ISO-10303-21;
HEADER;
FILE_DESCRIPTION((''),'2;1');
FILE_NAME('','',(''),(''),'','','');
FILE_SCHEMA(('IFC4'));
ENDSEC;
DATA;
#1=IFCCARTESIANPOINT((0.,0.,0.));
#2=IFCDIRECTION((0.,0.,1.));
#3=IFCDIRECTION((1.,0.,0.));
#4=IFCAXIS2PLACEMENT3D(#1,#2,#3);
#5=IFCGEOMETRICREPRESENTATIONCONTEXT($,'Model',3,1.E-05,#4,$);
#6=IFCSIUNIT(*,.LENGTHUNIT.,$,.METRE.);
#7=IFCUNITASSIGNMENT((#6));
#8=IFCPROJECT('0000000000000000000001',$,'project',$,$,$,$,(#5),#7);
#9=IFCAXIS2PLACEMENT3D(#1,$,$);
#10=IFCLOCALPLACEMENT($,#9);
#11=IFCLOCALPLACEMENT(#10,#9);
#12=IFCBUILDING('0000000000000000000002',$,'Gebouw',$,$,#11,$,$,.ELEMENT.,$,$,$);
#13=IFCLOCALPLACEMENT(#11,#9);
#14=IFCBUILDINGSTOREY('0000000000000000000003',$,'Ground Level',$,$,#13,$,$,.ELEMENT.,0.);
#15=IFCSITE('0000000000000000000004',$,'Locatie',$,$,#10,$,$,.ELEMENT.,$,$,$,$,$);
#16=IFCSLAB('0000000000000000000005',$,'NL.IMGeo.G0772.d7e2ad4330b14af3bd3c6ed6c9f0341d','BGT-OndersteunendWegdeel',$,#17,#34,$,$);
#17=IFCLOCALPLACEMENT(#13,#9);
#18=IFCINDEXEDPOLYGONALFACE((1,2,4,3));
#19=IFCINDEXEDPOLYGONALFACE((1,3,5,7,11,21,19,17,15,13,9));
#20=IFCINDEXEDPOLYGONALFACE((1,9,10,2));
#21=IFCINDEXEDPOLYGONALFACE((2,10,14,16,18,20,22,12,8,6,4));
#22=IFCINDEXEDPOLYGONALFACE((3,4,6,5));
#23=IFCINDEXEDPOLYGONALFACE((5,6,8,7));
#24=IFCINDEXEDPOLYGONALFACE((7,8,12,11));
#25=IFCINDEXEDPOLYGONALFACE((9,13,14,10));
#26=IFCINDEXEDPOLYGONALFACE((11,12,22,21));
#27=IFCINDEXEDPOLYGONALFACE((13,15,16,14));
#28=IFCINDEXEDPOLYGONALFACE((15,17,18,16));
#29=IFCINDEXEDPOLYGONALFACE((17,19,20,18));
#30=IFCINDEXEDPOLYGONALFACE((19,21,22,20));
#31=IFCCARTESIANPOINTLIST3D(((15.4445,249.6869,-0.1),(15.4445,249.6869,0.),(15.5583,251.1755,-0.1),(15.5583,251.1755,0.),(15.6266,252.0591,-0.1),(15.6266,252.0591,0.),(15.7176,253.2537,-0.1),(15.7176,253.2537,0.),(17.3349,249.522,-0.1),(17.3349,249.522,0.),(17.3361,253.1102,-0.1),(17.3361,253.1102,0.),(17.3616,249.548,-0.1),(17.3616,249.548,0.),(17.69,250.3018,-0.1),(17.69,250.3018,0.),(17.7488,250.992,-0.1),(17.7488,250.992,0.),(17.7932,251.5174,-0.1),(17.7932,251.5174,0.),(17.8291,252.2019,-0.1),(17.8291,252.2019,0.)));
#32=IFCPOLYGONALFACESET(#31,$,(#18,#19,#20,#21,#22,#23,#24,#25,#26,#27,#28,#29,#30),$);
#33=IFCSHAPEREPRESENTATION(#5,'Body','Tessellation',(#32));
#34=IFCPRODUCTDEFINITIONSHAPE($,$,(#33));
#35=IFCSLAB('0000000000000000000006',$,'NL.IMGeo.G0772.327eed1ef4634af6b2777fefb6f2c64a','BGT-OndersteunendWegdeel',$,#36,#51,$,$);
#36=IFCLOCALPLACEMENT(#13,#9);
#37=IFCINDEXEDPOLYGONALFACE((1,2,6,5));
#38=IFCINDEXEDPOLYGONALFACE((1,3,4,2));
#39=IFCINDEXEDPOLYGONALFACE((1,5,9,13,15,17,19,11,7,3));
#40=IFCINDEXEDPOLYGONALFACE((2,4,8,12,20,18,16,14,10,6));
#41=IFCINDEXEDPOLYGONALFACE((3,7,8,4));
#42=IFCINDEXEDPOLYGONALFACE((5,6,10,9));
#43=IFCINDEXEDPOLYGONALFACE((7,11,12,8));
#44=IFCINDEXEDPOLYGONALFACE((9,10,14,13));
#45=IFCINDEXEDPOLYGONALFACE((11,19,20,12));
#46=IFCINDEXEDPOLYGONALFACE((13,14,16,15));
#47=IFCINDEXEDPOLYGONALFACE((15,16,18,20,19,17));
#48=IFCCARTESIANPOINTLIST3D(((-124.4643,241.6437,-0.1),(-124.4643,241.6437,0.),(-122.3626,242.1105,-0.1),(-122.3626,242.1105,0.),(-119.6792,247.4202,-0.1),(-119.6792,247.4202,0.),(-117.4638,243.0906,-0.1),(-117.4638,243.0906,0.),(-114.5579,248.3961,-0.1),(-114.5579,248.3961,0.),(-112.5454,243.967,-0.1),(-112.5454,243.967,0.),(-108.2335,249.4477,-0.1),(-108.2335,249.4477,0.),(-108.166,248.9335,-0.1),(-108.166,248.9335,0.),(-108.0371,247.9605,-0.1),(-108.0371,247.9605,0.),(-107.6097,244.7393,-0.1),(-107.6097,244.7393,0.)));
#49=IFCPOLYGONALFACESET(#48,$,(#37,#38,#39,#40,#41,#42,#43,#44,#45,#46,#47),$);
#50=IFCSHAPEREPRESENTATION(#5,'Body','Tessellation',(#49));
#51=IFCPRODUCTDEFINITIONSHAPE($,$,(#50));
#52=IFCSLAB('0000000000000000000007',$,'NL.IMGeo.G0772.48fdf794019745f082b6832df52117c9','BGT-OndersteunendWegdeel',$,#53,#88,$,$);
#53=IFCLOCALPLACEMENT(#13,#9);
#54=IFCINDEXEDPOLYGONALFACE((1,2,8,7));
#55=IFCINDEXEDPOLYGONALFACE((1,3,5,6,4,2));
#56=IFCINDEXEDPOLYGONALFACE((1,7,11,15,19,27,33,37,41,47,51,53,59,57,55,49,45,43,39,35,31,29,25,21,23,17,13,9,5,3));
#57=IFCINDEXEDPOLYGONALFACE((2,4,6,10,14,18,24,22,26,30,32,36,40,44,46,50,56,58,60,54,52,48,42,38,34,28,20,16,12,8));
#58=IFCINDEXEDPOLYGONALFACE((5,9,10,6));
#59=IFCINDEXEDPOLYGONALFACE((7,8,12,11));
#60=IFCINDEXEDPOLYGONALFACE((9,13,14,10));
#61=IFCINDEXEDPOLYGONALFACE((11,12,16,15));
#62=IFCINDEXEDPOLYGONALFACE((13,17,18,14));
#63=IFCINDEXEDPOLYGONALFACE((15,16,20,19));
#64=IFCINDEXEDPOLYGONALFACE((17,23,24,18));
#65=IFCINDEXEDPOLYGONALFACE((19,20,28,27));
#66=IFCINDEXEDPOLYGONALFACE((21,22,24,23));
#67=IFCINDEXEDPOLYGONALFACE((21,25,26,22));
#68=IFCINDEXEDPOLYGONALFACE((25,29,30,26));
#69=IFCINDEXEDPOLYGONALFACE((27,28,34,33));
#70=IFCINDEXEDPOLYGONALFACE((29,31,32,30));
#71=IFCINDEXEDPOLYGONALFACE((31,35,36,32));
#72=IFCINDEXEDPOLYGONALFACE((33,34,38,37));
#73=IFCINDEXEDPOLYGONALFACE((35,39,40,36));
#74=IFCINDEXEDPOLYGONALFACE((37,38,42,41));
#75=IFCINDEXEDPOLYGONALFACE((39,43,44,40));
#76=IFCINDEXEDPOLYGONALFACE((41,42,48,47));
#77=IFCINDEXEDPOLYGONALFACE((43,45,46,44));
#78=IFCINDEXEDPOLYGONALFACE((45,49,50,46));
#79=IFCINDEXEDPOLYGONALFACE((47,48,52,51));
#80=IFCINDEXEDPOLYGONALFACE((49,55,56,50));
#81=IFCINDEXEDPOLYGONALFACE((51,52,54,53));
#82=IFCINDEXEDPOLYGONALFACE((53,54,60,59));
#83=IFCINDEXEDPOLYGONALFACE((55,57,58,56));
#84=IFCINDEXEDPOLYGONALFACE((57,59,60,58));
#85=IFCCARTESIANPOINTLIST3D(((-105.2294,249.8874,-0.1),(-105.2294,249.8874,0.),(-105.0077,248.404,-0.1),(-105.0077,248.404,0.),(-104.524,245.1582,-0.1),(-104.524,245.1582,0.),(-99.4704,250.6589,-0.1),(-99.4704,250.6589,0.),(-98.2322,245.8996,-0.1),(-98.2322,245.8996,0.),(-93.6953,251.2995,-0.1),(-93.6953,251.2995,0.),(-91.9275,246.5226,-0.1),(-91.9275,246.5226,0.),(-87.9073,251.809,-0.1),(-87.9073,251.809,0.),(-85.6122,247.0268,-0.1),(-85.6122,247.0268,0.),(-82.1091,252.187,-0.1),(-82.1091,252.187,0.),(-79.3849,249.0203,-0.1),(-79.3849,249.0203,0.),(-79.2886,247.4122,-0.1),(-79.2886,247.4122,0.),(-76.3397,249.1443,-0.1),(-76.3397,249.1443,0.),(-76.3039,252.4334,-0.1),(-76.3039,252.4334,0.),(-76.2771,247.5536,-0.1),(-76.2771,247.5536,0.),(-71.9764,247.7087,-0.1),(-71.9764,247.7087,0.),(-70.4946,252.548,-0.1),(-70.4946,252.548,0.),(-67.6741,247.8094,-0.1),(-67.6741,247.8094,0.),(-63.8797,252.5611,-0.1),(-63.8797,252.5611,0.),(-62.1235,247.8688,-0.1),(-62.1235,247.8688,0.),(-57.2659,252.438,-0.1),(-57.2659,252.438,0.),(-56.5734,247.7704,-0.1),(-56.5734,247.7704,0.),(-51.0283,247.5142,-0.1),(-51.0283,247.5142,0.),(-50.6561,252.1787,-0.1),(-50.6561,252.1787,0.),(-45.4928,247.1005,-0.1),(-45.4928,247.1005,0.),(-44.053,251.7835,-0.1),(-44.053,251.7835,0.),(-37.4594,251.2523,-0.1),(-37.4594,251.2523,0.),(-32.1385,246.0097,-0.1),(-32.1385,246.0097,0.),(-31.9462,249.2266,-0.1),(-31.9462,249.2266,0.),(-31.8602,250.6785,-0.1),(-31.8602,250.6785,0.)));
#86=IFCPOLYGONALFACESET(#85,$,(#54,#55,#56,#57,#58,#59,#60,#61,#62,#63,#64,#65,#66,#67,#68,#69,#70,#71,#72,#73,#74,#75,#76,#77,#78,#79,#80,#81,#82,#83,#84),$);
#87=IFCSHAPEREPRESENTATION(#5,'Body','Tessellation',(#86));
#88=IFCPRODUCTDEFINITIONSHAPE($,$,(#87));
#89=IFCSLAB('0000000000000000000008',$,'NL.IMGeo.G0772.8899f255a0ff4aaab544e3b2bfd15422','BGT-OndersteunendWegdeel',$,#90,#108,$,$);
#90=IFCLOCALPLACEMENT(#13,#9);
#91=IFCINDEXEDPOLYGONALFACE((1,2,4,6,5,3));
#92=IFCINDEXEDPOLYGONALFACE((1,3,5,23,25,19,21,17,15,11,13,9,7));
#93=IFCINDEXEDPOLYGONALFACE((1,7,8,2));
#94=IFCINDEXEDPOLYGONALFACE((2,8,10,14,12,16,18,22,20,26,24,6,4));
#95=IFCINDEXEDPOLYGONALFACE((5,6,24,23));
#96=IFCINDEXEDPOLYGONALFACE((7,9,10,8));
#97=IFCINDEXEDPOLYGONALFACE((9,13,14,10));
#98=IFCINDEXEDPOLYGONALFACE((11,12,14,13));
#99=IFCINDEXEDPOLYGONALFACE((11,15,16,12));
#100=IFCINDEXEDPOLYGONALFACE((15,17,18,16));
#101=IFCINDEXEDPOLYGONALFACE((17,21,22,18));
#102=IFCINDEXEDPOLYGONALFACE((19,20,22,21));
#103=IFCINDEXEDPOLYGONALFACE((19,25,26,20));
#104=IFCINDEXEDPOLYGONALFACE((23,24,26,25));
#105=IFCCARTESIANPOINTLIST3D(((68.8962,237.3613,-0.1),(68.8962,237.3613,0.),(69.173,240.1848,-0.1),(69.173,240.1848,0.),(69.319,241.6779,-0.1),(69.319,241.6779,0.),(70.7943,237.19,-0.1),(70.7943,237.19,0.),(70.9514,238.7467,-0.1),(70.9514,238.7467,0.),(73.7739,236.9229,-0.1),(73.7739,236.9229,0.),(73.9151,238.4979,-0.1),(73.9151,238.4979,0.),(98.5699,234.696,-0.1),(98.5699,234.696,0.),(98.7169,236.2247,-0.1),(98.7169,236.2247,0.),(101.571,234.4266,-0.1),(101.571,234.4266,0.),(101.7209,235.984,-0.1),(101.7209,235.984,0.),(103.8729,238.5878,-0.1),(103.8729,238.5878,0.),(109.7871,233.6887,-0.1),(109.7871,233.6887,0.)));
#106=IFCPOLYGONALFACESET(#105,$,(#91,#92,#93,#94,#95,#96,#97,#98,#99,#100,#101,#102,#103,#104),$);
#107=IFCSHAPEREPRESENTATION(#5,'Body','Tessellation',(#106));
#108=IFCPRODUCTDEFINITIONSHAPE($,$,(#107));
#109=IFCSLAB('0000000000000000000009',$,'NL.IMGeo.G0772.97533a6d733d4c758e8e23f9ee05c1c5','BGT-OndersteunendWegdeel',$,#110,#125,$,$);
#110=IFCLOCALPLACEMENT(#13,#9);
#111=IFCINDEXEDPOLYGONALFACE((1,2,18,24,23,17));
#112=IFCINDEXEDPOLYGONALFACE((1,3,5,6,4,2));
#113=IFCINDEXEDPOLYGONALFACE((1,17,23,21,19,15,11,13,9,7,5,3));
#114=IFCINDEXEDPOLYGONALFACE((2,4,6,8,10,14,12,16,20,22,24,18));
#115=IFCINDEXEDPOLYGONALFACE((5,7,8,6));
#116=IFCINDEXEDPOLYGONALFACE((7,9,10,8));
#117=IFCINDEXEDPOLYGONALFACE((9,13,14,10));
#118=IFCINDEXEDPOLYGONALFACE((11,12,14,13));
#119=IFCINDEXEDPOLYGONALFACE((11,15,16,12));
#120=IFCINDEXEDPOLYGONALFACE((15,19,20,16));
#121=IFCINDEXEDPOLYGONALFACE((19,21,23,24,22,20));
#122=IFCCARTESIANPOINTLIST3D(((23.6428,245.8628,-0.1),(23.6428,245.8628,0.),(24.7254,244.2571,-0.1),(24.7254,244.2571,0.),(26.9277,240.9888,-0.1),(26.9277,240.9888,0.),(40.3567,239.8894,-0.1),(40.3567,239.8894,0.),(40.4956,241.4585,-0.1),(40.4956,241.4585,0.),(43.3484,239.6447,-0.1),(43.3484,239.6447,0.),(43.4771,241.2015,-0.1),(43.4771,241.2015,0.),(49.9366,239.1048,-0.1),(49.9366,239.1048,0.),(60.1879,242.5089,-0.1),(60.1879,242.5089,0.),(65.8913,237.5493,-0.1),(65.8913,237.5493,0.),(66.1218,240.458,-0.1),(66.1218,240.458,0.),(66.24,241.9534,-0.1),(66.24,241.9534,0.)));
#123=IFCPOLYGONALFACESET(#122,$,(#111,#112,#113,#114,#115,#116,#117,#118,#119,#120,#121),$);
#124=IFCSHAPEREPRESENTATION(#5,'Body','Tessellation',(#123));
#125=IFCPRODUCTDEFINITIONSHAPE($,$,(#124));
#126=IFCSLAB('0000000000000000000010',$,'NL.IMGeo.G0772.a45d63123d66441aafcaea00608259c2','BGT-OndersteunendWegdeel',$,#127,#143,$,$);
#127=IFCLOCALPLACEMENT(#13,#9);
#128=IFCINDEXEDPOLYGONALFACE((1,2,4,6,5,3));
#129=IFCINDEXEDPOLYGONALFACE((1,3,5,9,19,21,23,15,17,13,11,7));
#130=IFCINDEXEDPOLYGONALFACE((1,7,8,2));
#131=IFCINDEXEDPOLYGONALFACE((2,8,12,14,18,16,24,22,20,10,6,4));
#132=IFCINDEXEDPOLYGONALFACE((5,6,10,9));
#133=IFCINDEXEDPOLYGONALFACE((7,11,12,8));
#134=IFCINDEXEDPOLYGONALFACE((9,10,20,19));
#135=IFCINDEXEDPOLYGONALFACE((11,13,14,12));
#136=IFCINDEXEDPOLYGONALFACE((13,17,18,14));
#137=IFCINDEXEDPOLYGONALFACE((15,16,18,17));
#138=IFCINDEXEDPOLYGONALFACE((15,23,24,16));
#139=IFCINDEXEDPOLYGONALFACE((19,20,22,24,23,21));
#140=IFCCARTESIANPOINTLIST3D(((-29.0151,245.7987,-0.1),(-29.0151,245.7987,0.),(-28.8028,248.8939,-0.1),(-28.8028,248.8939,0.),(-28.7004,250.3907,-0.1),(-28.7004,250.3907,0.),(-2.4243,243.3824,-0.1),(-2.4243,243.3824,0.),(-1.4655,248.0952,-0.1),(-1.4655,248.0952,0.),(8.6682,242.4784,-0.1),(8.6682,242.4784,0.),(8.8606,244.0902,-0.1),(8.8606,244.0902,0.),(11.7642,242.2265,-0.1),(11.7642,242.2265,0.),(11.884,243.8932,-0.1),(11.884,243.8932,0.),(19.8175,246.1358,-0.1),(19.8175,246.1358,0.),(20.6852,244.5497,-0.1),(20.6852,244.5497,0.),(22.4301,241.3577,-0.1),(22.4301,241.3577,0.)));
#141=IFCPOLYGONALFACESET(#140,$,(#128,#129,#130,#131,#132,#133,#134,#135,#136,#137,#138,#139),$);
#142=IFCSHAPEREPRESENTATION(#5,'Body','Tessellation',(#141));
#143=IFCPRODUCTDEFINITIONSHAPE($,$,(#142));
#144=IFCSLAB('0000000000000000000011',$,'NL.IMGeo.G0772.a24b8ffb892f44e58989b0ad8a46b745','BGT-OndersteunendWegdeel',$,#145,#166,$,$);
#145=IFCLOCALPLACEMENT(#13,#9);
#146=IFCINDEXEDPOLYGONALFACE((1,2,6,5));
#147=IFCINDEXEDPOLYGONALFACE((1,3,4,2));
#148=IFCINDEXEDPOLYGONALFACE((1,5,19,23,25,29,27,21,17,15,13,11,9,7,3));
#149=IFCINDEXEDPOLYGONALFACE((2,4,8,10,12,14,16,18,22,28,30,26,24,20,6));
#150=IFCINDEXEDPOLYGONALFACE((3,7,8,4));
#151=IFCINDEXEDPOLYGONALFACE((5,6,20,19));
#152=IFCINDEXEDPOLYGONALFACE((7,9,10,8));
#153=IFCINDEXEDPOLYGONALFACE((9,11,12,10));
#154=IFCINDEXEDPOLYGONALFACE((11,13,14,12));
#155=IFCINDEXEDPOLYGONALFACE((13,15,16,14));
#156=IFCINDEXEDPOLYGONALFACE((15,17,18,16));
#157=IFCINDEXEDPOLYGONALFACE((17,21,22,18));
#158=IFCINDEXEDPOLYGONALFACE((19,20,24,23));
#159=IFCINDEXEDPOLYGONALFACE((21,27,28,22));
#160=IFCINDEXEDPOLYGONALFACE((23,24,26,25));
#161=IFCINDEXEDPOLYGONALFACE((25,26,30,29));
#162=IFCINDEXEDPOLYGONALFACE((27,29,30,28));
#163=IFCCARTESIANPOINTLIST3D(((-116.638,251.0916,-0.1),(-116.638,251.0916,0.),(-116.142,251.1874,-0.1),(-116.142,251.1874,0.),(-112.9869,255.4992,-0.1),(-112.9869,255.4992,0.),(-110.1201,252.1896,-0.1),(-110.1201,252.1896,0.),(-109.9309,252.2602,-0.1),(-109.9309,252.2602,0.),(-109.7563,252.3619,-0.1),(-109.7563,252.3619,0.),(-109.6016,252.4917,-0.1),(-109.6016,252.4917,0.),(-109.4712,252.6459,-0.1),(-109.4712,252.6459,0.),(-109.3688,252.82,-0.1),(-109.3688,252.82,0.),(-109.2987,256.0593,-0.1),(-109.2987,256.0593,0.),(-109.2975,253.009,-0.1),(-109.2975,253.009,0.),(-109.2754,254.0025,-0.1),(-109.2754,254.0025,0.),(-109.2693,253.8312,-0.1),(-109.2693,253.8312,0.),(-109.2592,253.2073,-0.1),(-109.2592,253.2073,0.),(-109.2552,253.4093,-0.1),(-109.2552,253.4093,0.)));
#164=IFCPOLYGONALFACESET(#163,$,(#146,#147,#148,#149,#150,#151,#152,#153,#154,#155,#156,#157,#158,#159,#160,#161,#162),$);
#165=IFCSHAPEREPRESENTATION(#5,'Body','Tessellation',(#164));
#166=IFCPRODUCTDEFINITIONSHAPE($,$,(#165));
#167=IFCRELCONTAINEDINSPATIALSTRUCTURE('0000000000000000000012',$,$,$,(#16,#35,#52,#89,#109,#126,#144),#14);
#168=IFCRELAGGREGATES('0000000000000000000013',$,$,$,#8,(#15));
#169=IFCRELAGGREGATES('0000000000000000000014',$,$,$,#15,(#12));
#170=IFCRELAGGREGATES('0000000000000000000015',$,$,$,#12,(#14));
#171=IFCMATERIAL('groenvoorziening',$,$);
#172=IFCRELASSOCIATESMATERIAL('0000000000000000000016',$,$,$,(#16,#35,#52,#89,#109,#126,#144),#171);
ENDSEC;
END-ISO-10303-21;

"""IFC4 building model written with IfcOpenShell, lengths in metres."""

from ifc_helpers import new_model, si_unit, frame, origin, origin_with_axes, place, context, project, spatial, polyline, outline, extrude, material, element, save


model = new_model("IFC4")

# Units and contexts
model_context = context("Model", 3, precision=1e-05, world=origin_with_axes())
ifc_project = project(units=[si_unit("LENGTHUNIT", "METRE")], contexts=[model_context])

# Site, building, storey
site_placement = place(None, origin())
site = spatial("IfcSite", under=ifc_project, at=site_placement, Name="Locatie", CompositionType="ELEMENT")
building_placement = place(site_placement, origin())
building = spatial("IfcBuilding", under=site, at=building_placement, Name="Gebouw", CompositionType="ELEMENT")
storey_placement = place(building_placement, origin())
storey = spatial("IfcBuildingStorey", under=building, at=storey_placement, Name="Ground Level", CompositionType="ELEMENT", Elevation=0.0)

# Slabs
ifc_material_1 = material(Name="groenvoorziening")
slab_1_placement = place(storey_placement, origin())
element("IfcSlab", 1, at=slab_1_placement, inside=storey, material=ifc_material_1, Name="NL.IMGeo.G0772.d7e2ad4330b14af3bd3c6ed6c9f0341d", Description="BGT-OndersteunendWegdeel", context=model_context, shape_type="SweptSolid", body=[
    extrude(outline(polyline([(17.8291, 252.2019), (17.7932, 251.5174), (17.7488, 250.992), (17.69, 250.3018), (17.3616, 249.548), (17.3349, 249.522), (15.4445, 249.6869), (15.5583, 251.1755), (15.6266, 252.0591), (15.7176, 253.2537), (17.3361, 253.1102), (17.8291, 252.2019)])), frame((0.0, 0.0, -0.1), z_axis=(0.0, 0.0, 1.0), x_axis=(1.0, 0.0, 0.0)), (0.0, 0.0, 1.0), 0.1),
])
slab_2_placement = place(storey_placement, origin())
element("IfcSlab", 2, at=slab_2_placement, inside=storey, material=ifc_material_1, Name="NL.IMGeo.G0772.327eed1ef4634af6b2777fefb6f2c64a", Description="BGT-OndersteunendWegdeel", context=model_context, shape_type="SweptSolid", body=[
    extrude(outline(polyline([(-114.5579, 248.3961), (-108.2335, 249.4477), (-108.166, 248.9335), (-108.0371, 247.9605), (-107.6097, 244.7393), (-112.5454, 243.967), (-117.4638, 243.0906), (-122.3626, 242.1105), (-124.4643, 241.6437), (-119.6792, 247.4202), (-114.5579, 248.3961)])), frame((0.0, 0.0, -0.1), z_axis=(0.0, 0.0, 1.0), x_axis=(1.0, 0.0, 0.0)), (0.0, 0.0, 1.0), 0.1),
])
slab_3_placement = place(storey_placement, origin())
element("IfcSlab", 3, at=slab_3_placement, inside=storey, material=ifc_material_1, Name="NL.IMGeo.G0772.48fdf794019745f082b6832df52117c9", Description="BGT-OndersteunendWegdeel", context=model_context, shape_type="SweptSolid", body=[
    extrude(outline(polyline([(-99.4704, 250.6589), (-93.6953, 251.2995), (-87.9073, 251.809), (-82.1091, 252.187), (-76.3039, 252.4334), (-70.4946, 252.548), (-63.8797, 252.5611), (-57.2659, 252.438), (-50.6561, 252.1787), (-44.053, 251.7835), (-37.4594, 251.2523), (-31.8602, 250.6785), (-31.9462, 249.2266), (-32.1385, 246.0097), (-45.4928, 247.1005), (-51.0283, 247.5142), (-56.5734, 247.7704), (-62.1235, 247.8688), (-67.6741, 247.8094), (-71.9764, 247.7087), (-76.2771, 247.5536), (-76.3397, 249.1443), (-79.3849, 249.0203), (-79.2886, 247.4122), (-85.6122, 247.0268), (-91.9275, 246.5226), (-98.2322, 245.8996), (-104.524, 245.1582), (-105.0077, 248.404), (-105.2294, 249.8874), (-99.4704, 250.6589)])), frame((0.0, 0.0, -0.1), z_axis=(0.0, 0.0, 1.0), x_axis=(1.0, 0.0, 0.0)), (0.0, 0.0, 1.0), 0.1),
])
slab_4_placement = place(storey_placement, origin())
element("IfcSlab", 4, at=slab_4_placement, inside=storey, material=ifc_material_1, Name="NL.IMGeo.G0772.8899f255a0ff4aaab544e3b2bfd15422", Description="BGT-OndersteunendWegdeel", context=model_context, shape_type="SweptSolid", body=[
    extrude(outline(polyline([(101.571, 234.4266), (101.7209, 235.984), (98.7169, 236.2247), (98.5699, 234.696), (73.7739, 236.9229), (73.9151, 238.4979), (70.9514, 238.7467), (70.7943, 237.19), (68.8962, 237.3613), (69.173, 240.1848), (69.319, 241.6779), (103.8729, 238.5878), (109.7871, 233.6887), (101.571, 234.4266)])), frame((0.0, 0.0, -0.1), z_axis=(0.0, 0.0, 1.0), x_axis=(1.0, 0.0, 0.0)), (0.0, 0.0, 1.0), 0.1),
])
slab_5_placement = place(storey_placement, origin())
element("IfcSlab", 5, at=slab_5_placement, inside=storey, material=ifc_material_1, Name="NL.IMGeo.G0772.97533a6d733d4c758e8e23f9ee05c1c5", Description="BGT-OndersteunendWegdeel", context=model_context, shape_type="SweptSolid", body=[
    extrude(outline(polyline([(60.1879, 242.5089), (66.24, 241.9534), (66.1218, 240.458), (65.8913, 237.5493), (49.9366, 239.1048), (43.3484, 239.6447), (43.4771, 241.2015), (40.4956, 241.4585), (40.3567, 239.8894), (26.9277, 240.9888), (24.7254, 244.2571), (23.6428, 245.8628), (60.1879, 242.5089)])), frame((0.0, 0.0, -0.1), z_axis=(0.0, 0.0, 1.0), x_axis=(1.0, 0.0, 0.0)), (0.0, 0.0, 1.0), 0.1),
])
slab_6_placement = place(storey_placement, origin())
element("IfcSlab", 6, at=slab_6_placement, inside=storey, material=ifc_material_1, Name="NL.IMGeo.G0772.a45d63123d66441aafcaea00608259c2", Description="BGT-OndersteunendWegdeel", context=model_context, shape_type="SweptSolid", body=[
    extrude(outline(polyline([(-1.4655, 248.0952), (19.8175, 246.1358), (20.6852, 244.5497), (22.4301, 241.3577), (11.7642, 242.2265), (11.884, 243.8932), (8.8606, 244.0902), (8.6682, 242.4784), (-2.4243, 243.3824), (-29.0151, 245.7987), (-28.8028, 248.8939), (-28.7004, 250.3907), (-1.4655, 248.0952)])), frame((0.0, 0.0, -0.1), z_axis=(0.0, 0.0, 1.0), x_axis=(1.0, 0.0, 0.0)), (0.0, 0.0, 1.0), 0.1),
])
slab_7_placement = place(storey_placement, origin())
element("IfcSlab", 7, at=slab_7_placement, inside=storey, material=ifc_material_1, Name="NL.IMGeo.G0772.a24b8ffb892f44e58989b0ad8a46b745", Description="BGT-OndersteunendWegdeel", context=model_context, shape_type="SweptSolid", body=[
    extrude(outline(polyline([(-109.2987, 256.0593), (-109.2754, 254.0025), (-109.2693, 253.8312), (-109.2552, 253.4093), (-109.2592, 253.2073), (-109.2975, 253.009), (-109.3688, 252.82), (-109.4712, 252.6459), (-109.6016, 252.4917), (-109.7563, 252.3619), (-109.9309, 252.2602), (-110.1201, 252.1896), (-116.142, 251.1874), (-116.638, 251.0916), (-112.9869, 255.4992), (-109.2987, 256.0593)])), frame((0.0, 0.0, -0.1), z_axis=(0.0, 0.0, 1.0), x_axis=(1.0, 0.0, 0.0)), (0.0, 0.0, 1.0), 0.1),
])

save(model, "model.ifc")
